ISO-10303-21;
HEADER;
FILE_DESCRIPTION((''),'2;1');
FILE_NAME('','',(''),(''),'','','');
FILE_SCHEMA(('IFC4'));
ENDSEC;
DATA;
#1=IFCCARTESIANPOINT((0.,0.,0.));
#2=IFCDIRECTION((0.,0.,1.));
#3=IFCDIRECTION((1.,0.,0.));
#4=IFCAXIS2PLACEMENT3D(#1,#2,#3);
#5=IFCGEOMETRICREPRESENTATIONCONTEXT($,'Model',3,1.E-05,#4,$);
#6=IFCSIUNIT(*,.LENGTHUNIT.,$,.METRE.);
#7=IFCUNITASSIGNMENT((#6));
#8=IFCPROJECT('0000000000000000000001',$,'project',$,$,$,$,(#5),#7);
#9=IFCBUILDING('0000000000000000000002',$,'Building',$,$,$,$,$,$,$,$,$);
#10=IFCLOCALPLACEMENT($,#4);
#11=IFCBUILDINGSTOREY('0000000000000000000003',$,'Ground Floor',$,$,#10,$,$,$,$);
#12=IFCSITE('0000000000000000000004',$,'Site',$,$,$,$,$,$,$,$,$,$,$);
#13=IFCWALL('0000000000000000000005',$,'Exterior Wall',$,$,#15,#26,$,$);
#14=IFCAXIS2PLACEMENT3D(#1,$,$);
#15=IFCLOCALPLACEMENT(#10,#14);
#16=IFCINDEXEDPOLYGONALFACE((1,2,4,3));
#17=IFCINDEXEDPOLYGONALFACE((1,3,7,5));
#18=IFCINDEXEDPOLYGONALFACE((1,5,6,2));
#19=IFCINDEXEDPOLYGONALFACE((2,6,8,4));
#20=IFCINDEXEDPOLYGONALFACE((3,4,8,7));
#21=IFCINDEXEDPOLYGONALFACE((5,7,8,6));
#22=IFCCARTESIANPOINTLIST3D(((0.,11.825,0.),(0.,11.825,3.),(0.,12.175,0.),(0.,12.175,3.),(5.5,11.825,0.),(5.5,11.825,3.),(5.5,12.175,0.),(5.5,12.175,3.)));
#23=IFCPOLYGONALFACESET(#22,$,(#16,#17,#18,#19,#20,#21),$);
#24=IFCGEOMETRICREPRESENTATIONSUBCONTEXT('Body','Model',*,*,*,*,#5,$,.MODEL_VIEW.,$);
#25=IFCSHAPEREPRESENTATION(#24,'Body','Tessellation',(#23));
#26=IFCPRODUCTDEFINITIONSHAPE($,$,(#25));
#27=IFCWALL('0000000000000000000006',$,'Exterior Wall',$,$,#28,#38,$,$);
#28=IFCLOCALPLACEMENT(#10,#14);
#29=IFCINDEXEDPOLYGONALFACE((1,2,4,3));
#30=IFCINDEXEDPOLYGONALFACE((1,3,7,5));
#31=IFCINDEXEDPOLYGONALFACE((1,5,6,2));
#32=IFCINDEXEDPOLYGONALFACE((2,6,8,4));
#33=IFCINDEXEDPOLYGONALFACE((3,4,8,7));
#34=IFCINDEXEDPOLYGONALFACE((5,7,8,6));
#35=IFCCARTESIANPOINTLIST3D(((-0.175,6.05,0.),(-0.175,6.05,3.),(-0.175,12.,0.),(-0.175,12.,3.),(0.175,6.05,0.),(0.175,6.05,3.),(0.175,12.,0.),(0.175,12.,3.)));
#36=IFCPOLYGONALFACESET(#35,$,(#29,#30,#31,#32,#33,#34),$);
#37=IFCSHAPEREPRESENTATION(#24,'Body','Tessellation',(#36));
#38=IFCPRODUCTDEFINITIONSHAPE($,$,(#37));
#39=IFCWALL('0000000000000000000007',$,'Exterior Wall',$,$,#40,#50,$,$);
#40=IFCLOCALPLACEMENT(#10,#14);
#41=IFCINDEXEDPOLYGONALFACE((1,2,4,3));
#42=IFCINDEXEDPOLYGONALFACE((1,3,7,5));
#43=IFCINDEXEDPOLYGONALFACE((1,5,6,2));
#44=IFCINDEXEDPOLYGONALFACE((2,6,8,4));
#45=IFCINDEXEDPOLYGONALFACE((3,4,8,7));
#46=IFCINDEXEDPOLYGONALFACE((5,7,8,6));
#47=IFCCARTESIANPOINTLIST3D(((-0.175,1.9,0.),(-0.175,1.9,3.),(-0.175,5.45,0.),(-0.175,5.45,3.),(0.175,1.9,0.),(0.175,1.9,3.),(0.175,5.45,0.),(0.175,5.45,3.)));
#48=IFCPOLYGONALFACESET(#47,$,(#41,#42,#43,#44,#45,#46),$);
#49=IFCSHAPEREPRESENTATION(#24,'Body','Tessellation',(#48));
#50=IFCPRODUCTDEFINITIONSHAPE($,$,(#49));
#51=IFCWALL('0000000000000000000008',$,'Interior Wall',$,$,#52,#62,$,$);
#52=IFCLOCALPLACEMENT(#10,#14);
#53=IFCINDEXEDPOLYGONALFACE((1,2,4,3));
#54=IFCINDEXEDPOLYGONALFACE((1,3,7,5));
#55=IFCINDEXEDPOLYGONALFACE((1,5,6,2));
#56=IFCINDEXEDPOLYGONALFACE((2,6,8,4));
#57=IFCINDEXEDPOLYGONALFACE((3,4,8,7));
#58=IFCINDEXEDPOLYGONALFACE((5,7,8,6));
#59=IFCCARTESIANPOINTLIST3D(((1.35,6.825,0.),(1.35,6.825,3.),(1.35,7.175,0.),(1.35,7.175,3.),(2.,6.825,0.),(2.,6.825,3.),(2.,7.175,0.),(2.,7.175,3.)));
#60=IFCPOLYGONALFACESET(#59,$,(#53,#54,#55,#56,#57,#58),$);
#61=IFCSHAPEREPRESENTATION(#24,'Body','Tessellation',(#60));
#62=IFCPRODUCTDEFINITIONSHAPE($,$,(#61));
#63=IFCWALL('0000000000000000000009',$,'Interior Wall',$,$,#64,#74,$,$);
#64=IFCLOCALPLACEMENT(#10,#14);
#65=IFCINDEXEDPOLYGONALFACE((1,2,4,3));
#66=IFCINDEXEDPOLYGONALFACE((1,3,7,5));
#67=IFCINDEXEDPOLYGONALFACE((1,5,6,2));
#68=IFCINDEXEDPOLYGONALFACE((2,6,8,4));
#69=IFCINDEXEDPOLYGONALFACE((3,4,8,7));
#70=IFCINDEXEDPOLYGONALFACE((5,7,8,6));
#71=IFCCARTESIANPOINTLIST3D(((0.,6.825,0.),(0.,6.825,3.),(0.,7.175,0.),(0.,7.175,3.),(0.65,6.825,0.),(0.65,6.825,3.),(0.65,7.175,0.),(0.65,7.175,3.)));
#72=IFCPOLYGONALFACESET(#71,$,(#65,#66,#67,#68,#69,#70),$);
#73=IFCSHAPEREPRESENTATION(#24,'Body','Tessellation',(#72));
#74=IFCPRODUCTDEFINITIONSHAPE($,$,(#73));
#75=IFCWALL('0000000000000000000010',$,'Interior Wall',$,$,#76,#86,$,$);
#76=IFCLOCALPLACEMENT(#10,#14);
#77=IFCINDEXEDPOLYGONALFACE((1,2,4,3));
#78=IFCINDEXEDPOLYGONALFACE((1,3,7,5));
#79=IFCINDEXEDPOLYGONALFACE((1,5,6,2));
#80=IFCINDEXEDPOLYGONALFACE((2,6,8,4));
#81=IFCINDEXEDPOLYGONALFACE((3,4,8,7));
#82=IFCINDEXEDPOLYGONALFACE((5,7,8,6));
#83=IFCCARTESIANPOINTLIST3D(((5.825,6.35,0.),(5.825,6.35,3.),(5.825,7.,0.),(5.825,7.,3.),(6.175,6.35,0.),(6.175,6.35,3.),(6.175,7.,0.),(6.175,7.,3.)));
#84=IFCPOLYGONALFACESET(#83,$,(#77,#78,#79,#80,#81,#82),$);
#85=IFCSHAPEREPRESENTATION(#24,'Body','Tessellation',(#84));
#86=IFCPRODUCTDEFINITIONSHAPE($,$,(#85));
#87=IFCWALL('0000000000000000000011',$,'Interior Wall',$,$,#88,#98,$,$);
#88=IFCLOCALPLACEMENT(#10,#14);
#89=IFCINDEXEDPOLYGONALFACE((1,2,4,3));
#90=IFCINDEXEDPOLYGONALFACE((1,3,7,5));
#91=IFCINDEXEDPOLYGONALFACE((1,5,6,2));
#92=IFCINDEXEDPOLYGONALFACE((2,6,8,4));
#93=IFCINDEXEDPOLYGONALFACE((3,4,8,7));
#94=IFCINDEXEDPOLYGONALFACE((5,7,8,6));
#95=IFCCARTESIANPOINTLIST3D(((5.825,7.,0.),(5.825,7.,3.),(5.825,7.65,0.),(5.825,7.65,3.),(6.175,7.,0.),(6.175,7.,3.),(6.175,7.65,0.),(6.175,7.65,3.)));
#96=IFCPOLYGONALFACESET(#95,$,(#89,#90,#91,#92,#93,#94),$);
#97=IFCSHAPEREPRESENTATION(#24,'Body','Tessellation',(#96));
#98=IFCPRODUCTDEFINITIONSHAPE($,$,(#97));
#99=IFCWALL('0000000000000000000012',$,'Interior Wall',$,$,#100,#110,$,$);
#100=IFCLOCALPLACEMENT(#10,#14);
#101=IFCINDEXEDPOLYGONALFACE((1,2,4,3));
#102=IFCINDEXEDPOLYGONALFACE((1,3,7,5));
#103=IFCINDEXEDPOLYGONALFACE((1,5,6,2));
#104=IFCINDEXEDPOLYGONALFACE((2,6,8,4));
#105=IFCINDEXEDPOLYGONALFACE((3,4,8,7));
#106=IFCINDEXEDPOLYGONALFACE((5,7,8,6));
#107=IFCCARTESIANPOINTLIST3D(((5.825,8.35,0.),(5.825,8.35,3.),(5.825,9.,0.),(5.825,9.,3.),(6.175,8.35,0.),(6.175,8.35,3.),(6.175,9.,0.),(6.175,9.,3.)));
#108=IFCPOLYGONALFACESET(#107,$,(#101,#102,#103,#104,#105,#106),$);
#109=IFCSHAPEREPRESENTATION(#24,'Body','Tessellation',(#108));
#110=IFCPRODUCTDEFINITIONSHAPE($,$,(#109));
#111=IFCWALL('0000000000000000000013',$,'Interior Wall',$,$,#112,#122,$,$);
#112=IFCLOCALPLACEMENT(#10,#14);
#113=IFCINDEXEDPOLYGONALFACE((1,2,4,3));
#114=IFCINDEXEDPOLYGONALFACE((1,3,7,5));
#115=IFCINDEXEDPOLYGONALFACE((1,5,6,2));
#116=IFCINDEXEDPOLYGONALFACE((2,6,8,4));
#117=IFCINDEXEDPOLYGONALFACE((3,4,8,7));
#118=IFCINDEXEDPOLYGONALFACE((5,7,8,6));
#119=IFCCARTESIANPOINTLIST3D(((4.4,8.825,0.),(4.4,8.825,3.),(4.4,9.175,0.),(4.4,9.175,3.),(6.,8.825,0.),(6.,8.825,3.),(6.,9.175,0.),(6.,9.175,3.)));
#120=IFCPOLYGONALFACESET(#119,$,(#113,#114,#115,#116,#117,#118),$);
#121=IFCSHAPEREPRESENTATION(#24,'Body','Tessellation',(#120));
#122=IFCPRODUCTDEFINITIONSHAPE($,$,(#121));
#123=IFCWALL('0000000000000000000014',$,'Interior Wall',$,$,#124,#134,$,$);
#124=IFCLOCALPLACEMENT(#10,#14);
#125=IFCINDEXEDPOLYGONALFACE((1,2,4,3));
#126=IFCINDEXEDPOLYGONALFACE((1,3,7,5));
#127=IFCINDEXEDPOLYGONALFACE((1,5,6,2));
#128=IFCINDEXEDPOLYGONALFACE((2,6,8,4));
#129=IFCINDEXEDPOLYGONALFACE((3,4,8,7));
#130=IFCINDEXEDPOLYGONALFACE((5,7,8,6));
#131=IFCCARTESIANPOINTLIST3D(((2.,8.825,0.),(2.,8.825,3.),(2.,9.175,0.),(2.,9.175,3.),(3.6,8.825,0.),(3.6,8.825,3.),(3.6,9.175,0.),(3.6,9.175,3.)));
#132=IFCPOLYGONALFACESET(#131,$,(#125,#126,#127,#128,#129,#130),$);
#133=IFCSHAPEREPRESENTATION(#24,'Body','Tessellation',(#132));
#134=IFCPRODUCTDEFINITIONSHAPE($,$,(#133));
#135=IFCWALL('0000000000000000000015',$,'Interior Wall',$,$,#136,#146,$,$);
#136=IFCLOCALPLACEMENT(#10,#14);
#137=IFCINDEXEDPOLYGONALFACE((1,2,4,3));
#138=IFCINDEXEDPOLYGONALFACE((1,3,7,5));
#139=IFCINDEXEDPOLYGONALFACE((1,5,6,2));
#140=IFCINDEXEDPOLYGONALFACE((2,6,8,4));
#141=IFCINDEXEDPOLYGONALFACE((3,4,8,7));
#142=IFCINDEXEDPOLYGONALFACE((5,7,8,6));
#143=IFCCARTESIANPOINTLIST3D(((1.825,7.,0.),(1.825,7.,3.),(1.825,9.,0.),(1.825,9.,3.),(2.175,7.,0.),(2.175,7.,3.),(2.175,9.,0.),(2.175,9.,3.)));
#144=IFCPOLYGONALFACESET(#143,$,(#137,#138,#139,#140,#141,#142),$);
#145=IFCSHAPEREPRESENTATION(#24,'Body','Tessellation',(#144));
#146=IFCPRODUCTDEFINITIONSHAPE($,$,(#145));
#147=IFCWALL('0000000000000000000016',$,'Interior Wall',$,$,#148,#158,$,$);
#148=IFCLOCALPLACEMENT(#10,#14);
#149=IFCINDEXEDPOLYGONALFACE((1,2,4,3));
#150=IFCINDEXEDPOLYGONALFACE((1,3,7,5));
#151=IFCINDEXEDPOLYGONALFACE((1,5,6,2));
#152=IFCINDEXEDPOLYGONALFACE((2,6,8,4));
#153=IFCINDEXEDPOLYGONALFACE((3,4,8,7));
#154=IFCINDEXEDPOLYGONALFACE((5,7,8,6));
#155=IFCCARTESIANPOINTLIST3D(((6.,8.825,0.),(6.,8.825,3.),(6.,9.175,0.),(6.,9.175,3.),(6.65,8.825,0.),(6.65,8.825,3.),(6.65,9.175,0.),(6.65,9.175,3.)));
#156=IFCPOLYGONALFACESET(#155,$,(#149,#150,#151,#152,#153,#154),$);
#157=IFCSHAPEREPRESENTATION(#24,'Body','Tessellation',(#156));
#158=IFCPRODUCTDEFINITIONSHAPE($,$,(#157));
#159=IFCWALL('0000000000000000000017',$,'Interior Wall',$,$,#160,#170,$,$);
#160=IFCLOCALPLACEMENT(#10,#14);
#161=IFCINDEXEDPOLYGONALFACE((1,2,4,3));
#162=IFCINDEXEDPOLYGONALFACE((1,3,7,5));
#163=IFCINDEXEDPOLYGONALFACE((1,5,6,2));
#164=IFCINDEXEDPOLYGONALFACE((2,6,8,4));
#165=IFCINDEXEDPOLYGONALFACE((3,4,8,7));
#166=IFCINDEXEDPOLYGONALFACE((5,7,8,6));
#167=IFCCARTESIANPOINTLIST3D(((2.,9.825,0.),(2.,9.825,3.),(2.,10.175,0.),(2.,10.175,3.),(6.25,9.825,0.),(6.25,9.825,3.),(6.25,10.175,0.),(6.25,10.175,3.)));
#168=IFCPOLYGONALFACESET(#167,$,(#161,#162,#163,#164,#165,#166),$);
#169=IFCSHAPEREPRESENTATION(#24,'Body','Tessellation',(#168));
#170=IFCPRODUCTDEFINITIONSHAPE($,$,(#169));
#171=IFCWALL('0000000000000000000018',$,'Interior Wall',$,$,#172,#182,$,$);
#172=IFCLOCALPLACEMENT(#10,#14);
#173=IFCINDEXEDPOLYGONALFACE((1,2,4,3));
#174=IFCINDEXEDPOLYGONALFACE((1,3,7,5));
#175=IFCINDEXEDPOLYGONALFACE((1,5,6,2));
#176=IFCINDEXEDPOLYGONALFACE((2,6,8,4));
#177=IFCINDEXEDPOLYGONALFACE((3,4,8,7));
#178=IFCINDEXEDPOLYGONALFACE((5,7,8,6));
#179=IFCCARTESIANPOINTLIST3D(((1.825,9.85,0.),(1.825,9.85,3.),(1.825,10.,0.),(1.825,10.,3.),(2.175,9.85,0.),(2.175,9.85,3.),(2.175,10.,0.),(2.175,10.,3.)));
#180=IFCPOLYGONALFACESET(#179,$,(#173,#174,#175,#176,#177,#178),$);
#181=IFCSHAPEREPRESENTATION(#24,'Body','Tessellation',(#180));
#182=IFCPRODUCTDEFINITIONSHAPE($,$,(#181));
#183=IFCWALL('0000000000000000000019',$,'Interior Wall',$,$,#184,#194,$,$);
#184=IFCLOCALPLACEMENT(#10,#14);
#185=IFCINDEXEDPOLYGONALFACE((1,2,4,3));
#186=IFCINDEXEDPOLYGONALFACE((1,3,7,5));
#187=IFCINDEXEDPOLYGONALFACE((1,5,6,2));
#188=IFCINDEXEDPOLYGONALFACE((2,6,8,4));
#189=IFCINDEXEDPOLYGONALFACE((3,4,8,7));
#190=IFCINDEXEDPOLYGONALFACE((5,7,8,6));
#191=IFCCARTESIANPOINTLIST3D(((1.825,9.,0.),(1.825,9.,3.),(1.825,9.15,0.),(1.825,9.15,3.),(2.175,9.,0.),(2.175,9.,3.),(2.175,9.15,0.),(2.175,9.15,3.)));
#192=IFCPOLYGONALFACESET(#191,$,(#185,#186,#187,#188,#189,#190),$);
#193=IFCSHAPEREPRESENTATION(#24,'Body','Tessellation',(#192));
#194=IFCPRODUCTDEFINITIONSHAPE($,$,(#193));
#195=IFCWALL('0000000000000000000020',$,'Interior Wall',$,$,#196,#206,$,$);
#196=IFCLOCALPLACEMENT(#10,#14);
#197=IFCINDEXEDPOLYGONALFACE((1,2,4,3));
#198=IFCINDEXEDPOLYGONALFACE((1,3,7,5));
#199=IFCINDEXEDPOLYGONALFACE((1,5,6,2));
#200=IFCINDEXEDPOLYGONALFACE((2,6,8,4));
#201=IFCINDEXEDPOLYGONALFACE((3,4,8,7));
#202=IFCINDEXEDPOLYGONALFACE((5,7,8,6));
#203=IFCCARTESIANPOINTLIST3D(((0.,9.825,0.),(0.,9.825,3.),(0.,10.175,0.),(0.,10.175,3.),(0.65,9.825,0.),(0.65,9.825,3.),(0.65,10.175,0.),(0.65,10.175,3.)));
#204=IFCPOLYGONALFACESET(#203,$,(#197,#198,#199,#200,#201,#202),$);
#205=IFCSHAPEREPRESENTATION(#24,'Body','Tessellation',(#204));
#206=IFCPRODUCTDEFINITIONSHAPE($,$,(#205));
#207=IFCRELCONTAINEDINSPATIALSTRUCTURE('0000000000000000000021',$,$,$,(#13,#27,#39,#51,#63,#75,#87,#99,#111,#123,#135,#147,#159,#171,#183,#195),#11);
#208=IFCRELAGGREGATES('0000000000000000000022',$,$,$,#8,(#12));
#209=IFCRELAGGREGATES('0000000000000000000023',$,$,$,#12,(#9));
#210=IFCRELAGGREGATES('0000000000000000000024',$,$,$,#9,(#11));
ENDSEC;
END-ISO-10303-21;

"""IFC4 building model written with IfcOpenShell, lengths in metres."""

from ifc_helpers import new_model, si_unit, frame, origin_with_axes, place, context, subcontext, project, spatial, indexed_curve, outline, extrude, element, save


model = new_model("IFC4")

# Units and contexts
model_context = context("Model", 3, precision=1e-05, world=origin_with_axes())
body_context = subcontext(model_context, "Body", "Model", "MODEL_VIEW")
ifc_project = project(units=[si_unit("LENGTHUNIT", "METRE")], contexts=[model_context])

# Site, building, storey
site = spatial("IfcSite", under=ifc_project, Name="Site")
building = spatial("IfcBuilding", under=site, Name="Building")
storey_placement = place(None, origin_with_axes())
storey = spatial("IfcBuildingStorey", under=building, at=storey_placement, Name="Ground Floor")

# Walls
wall_1_placement = place(storey_placement, frame((5.5, 12.0, 0.0), z_axis=(0.0, 0.0, 1.0), x_axis=(-1.0, 0.0, 0.0)))
element("IfcWall", 1, at=wall_1_placement, inside=storey, Name="Exterior Wall", context=body_context, shape_type="SweptSolid", body=[
    extrude(outline(indexed_curve([(0.0, 0.0), (0.0, 0.35), (5.5, 0.35), (5.5, 0.0), (0.0, 0.0)], self_intersect=False)), frame((0.0, -0.175, 0.0), z_axis=(0.0, 0.0, 1.0), x_axis=(1.0, 0.0, 0.0)), (0.0, 0.0, 1.0), 3.0),
])
wall_2_placement = place(storey_placement, frame((0.0, 12.0, 0.0), z_axis=(0.0, 0.0, 1.0), x_axis=(0.0, -1.0, 0.0)))
element("IfcWall", 2, at=wall_2_placement, inside=storey, Name="Exterior Wall", context=body_context, shape_type="SweptSolid", body=[
    extrude(outline(indexed_curve([(0.0, 0.0), (0.0, 0.35), (5.95, 0.35), (5.95, 0.0), (0.0, 0.0)], self_intersect=False)), frame((0.0, -0.175, 0.0), z_axis=(0.0, 0.0, 1.0), x_axis=(1.0, 0.0, 0.0)), (0.0, 0.0, 1.0), 3.0),
])
wall_3_placement = place(storey_placement, frame((0.0, 5.45, 0.0), z_axis=(0.0, 0.0, 1.0), x_axis=(0.0, -1.0, 0.0)))
element("IfcWall", 3, at=wall_3_placement, inside=storey, Name="Exterior Wall", context=body_context, shape_type="SweptSolid", body=[
    extrude(outline(indexed_curve([(0.0, 0.0), (0.0, 0.35), (3.55, 0.35), (3.55, 0.0), (0.0, 0.0)], self_intersect=False)), frame((0.0, -0.175, 0.0), z_axis=(0.0, 0.0, 1.0), x_axis=(1.0, 0.0, 0.0)), (0.0, 0.0, 1.0), 3.0),
])
for number, where, z_axis, x_axis, name in (
    (4, (2.0, 7.0, 0.0), (0.0, 0.0, 1.0), (-1.0, 0.0, 0.0), "Interior Wall"),
    (5, (0.65, 7.0, 0.0), (0.0, 0.0, 1.0), (-1.0, 0.0, 0.0), "Interior Wall"),
):
    element("IfcWall", number, at=place(storey_placement, frame(where, z_axis=z_axis, x_axis=x_axis)), inside=storey, Name=name, context=body_context, shape_type="SweptSolid", body=[
        extrude(outline(indexed_curve([(0.0, 0.0), (0.0, 0.35), (0.65, 0.35), (0.65, 0.0), (0.0, 0.0)], self_intersect=False)), frame((0.0, -0.175, 0.0), z_axis=(0.0, 0.0, 1.0), x_axis=(1.0, 0.0, 0.0)), (0.0, 0.0, 1.0), 3.0),
    ])
for number, where, z_axis, x_axis, name in (
    (6, (6.0, 6.35, 0.0), (0.0, 0.0, 1.0), (0.0, 1.0, 0.0), "Interior Wall"),
    (7, (6.0, 7.0, 0.0), (0.0, 0.0, 1.0), (0.0, 1.0, 0.0), "Interior Wall"),
    (8, (6.0, 8.35, 0.0), (0.0, 0.0, 1.0), (0.0, 1.0, 0.0), "Interior Wall"),
):
    element("IfcWall", number, at=place(storey_placement, frame(where, z_axis=z_axis, x_axis=x_axis)), inside=storey, Name=name, context=body_context, shape_type="SweptSolid", body=[
        extrude(outline(indexed_curve([(0.0, 0.0), (0.0, 0.35), (0.65, 0.35), (0.65, 0.0), (0.0, 0.0)], self_intersect=False)), frame((0.0, -0.175, 0.0), z_axis=(0.0, 0.0, 1.0), x_axis=(1.0, 0.0, 0.0)), (0.0, 0.0, 1.0), 3.0),
    ])
wall_4_placement = place(storey_placement, frame((6.0, 9.0, 0.0), z_axis=(0.0, 0.0, 1.0), x_axis=(-1.0, 0.0, 0.0)))
element("IfcWall", 9, at=wall_4_placement, inside=storey, Name="Interior Wall", context=body_context, shape_type="SweptSolid", body=[
    extrude(outline(indexed_curve([(0.0, 0.0), (0.0, 0.35), (1.6, 0.35), (1.6, 0.0), (0.0, 0.0)], self_intersect=False)), frame((0.0, -0.175, 0.0), z_axis=(0.0, 0.0, 1.0), x_axis=(1.0, 0.0, 0.0)), (0.0, 0.0, 1.0), 3.0),
])
wall_5_placement = place(storey_placement, frame((3.6, 9.0, 0.0), z_axis=(0.0, 0.0, 1.0), x_axis=(-1.0, 0.0, 0.0)))
element("IfcWall", 10, at=wall_5_placement, inside=storey, Name="Interior Wall", context=body_context, shape_type="SweptSolid", body=[
    extrude(outline(indexed_curve([(0.0, 0.0), (0.0, 0.35), (1.6, 0.35), (1.6, 0.0), (0.0, 0.0)], self_intersect=False)), frame((0.0, -0.175, 0.0), z_axis=(0.0, 0.0, 1.0), x_axis=(1.0, 0.0, 0.0)), (0.0, 0.0, 1.0), 3.0),
])
wall_6_placement = place(storey_placement, frame((2.0, 9.0, 0.0), z_axis=(0.0, 0.0, 1.0), x_axis=(0.0, -1.0, 0.0)))
element("IfcWall", 11, at=wall_6_placement, inside=storey, Name="Interior Wall", context=body_context, shape_type="SweptSolid", body=[
    extrude(outline(indexed_curve([(0.0, 0.0), (0.0, 0.35), (2.0, 0.35), (2.0, 0.0), (0.0, 0.0)], self_intersect=False)), frame((0.0, -0.175, 0.0), z_axis=(0.0, 0.0, 1.0), x_axis=(1.0, 0.0, 0.0)), (0.0, 0.0, 1.0), 3.0),
])
wall_7_placement = place(storey_placement, frame((6.65, 9.0, 0.0), z_axis=(0.0, 0.0, 1.0), x_axis=(-1.0, 0.0, 0.0)))
element("IfcWall", 12, at=wall_7_placement, inside=storey, Name="Interior Wall", context=body_context, shape_type="SweptSolid", body=[
    extrude(outline(indexed_curve([(0.0, 0.0), (0.0, 0.35), (0.65, 0.35), (0.65, 0.0), (0.0, 0.0)], self_intersect=False)), frame((0.0, -0.175, 0.0), z_axis=(0.0, 0.0, 1.0), x_axis=(1.0, 0.0, 0.0)), (0.0, 0.0, 1.0), 3.0),
])
wall_8_placement = place(storey_placement, frame((6.25, 10.0, 0.0), z_axis=(0.0, 0.0, 1.0), x_axis=(-1.0, 0.0, 0.0)))
element("IfcWall", 13, at=wall_8_placement, inside=storey, Name="Interior Wall", context=body_context, shape_type="SweptSolid", body=[
    extrude(outline(indexed_curve([(0.0, 0.0), (0.0, 0.35), (4.25, 0.35), (4.25, 0.0), (0.0, 0.0)], self_intersect=False)), frame((0.0, -0.175, 0.0), z_axis=(0.0, 0.0, 1.0), x_axis=(1.0, 0.0, 0.0)), (0.0, 0.0, 1.0), 3.0),
])
for number, where, z_axis, x_axis, name in (
    (14, (2.0, 10.0, 0.0), (0.0, 0.0, 1.0), (0.0, -1.0, 0.0), "Interior Wall"),
    (15, (2.0, 9.15, 0.0), (0.0, 0.0, 1.0), (0.0, -1.0, 0.0), "Interior Wall"),
):
    element("IfcWall", number, at=place(storey_placement, frame(where, z_axis=z_axis, x_axis=x_axis)), inside=storey, Name=name, context=body_context, shape_type="SweptSolid", body=[
        extrude(outline(indexed_curve([(0.0, 0.0), (0.0, 0.35), (0.15, 0.35), (0.15, 0.0), (0.0, 0.0)], self_intersect=False)), frame((0.0, -0.175, 0.0), z_axis=(0.0, 0.0, 1.0), x_axis=(1.0, 0.0, 0.0)), (0.0, 0.0, 1.0), 3.0),
    ])
wall_9_placement = place(storey_placement, frame((0.0, 10.0, 0.0), z_axis=(0.0, 0.0, 1.0), x_axis=(1.0, 0.0, 0.0)))
element("IfcWall", 16, at=wall_9_placement, inside=storey, Name="Interior Wall", context=body_context, shape_type="SweptSolid", body=[
    extrude(outline(indexed_curve([(0.0, 0.0), (0.0, 0.35), (0.65, 0.35), (0.65, 0.0), (0.0, 0.0)], self_intersect=False)), frame((0.0, -0.175, 0.0), z_axis=(0.0, 0.0, 1.0), x_axis=(1.0, 0.0, 0.0)), (0.0, 0.0, 1.0), 3.0),
])

save(model, "model.ifc")
